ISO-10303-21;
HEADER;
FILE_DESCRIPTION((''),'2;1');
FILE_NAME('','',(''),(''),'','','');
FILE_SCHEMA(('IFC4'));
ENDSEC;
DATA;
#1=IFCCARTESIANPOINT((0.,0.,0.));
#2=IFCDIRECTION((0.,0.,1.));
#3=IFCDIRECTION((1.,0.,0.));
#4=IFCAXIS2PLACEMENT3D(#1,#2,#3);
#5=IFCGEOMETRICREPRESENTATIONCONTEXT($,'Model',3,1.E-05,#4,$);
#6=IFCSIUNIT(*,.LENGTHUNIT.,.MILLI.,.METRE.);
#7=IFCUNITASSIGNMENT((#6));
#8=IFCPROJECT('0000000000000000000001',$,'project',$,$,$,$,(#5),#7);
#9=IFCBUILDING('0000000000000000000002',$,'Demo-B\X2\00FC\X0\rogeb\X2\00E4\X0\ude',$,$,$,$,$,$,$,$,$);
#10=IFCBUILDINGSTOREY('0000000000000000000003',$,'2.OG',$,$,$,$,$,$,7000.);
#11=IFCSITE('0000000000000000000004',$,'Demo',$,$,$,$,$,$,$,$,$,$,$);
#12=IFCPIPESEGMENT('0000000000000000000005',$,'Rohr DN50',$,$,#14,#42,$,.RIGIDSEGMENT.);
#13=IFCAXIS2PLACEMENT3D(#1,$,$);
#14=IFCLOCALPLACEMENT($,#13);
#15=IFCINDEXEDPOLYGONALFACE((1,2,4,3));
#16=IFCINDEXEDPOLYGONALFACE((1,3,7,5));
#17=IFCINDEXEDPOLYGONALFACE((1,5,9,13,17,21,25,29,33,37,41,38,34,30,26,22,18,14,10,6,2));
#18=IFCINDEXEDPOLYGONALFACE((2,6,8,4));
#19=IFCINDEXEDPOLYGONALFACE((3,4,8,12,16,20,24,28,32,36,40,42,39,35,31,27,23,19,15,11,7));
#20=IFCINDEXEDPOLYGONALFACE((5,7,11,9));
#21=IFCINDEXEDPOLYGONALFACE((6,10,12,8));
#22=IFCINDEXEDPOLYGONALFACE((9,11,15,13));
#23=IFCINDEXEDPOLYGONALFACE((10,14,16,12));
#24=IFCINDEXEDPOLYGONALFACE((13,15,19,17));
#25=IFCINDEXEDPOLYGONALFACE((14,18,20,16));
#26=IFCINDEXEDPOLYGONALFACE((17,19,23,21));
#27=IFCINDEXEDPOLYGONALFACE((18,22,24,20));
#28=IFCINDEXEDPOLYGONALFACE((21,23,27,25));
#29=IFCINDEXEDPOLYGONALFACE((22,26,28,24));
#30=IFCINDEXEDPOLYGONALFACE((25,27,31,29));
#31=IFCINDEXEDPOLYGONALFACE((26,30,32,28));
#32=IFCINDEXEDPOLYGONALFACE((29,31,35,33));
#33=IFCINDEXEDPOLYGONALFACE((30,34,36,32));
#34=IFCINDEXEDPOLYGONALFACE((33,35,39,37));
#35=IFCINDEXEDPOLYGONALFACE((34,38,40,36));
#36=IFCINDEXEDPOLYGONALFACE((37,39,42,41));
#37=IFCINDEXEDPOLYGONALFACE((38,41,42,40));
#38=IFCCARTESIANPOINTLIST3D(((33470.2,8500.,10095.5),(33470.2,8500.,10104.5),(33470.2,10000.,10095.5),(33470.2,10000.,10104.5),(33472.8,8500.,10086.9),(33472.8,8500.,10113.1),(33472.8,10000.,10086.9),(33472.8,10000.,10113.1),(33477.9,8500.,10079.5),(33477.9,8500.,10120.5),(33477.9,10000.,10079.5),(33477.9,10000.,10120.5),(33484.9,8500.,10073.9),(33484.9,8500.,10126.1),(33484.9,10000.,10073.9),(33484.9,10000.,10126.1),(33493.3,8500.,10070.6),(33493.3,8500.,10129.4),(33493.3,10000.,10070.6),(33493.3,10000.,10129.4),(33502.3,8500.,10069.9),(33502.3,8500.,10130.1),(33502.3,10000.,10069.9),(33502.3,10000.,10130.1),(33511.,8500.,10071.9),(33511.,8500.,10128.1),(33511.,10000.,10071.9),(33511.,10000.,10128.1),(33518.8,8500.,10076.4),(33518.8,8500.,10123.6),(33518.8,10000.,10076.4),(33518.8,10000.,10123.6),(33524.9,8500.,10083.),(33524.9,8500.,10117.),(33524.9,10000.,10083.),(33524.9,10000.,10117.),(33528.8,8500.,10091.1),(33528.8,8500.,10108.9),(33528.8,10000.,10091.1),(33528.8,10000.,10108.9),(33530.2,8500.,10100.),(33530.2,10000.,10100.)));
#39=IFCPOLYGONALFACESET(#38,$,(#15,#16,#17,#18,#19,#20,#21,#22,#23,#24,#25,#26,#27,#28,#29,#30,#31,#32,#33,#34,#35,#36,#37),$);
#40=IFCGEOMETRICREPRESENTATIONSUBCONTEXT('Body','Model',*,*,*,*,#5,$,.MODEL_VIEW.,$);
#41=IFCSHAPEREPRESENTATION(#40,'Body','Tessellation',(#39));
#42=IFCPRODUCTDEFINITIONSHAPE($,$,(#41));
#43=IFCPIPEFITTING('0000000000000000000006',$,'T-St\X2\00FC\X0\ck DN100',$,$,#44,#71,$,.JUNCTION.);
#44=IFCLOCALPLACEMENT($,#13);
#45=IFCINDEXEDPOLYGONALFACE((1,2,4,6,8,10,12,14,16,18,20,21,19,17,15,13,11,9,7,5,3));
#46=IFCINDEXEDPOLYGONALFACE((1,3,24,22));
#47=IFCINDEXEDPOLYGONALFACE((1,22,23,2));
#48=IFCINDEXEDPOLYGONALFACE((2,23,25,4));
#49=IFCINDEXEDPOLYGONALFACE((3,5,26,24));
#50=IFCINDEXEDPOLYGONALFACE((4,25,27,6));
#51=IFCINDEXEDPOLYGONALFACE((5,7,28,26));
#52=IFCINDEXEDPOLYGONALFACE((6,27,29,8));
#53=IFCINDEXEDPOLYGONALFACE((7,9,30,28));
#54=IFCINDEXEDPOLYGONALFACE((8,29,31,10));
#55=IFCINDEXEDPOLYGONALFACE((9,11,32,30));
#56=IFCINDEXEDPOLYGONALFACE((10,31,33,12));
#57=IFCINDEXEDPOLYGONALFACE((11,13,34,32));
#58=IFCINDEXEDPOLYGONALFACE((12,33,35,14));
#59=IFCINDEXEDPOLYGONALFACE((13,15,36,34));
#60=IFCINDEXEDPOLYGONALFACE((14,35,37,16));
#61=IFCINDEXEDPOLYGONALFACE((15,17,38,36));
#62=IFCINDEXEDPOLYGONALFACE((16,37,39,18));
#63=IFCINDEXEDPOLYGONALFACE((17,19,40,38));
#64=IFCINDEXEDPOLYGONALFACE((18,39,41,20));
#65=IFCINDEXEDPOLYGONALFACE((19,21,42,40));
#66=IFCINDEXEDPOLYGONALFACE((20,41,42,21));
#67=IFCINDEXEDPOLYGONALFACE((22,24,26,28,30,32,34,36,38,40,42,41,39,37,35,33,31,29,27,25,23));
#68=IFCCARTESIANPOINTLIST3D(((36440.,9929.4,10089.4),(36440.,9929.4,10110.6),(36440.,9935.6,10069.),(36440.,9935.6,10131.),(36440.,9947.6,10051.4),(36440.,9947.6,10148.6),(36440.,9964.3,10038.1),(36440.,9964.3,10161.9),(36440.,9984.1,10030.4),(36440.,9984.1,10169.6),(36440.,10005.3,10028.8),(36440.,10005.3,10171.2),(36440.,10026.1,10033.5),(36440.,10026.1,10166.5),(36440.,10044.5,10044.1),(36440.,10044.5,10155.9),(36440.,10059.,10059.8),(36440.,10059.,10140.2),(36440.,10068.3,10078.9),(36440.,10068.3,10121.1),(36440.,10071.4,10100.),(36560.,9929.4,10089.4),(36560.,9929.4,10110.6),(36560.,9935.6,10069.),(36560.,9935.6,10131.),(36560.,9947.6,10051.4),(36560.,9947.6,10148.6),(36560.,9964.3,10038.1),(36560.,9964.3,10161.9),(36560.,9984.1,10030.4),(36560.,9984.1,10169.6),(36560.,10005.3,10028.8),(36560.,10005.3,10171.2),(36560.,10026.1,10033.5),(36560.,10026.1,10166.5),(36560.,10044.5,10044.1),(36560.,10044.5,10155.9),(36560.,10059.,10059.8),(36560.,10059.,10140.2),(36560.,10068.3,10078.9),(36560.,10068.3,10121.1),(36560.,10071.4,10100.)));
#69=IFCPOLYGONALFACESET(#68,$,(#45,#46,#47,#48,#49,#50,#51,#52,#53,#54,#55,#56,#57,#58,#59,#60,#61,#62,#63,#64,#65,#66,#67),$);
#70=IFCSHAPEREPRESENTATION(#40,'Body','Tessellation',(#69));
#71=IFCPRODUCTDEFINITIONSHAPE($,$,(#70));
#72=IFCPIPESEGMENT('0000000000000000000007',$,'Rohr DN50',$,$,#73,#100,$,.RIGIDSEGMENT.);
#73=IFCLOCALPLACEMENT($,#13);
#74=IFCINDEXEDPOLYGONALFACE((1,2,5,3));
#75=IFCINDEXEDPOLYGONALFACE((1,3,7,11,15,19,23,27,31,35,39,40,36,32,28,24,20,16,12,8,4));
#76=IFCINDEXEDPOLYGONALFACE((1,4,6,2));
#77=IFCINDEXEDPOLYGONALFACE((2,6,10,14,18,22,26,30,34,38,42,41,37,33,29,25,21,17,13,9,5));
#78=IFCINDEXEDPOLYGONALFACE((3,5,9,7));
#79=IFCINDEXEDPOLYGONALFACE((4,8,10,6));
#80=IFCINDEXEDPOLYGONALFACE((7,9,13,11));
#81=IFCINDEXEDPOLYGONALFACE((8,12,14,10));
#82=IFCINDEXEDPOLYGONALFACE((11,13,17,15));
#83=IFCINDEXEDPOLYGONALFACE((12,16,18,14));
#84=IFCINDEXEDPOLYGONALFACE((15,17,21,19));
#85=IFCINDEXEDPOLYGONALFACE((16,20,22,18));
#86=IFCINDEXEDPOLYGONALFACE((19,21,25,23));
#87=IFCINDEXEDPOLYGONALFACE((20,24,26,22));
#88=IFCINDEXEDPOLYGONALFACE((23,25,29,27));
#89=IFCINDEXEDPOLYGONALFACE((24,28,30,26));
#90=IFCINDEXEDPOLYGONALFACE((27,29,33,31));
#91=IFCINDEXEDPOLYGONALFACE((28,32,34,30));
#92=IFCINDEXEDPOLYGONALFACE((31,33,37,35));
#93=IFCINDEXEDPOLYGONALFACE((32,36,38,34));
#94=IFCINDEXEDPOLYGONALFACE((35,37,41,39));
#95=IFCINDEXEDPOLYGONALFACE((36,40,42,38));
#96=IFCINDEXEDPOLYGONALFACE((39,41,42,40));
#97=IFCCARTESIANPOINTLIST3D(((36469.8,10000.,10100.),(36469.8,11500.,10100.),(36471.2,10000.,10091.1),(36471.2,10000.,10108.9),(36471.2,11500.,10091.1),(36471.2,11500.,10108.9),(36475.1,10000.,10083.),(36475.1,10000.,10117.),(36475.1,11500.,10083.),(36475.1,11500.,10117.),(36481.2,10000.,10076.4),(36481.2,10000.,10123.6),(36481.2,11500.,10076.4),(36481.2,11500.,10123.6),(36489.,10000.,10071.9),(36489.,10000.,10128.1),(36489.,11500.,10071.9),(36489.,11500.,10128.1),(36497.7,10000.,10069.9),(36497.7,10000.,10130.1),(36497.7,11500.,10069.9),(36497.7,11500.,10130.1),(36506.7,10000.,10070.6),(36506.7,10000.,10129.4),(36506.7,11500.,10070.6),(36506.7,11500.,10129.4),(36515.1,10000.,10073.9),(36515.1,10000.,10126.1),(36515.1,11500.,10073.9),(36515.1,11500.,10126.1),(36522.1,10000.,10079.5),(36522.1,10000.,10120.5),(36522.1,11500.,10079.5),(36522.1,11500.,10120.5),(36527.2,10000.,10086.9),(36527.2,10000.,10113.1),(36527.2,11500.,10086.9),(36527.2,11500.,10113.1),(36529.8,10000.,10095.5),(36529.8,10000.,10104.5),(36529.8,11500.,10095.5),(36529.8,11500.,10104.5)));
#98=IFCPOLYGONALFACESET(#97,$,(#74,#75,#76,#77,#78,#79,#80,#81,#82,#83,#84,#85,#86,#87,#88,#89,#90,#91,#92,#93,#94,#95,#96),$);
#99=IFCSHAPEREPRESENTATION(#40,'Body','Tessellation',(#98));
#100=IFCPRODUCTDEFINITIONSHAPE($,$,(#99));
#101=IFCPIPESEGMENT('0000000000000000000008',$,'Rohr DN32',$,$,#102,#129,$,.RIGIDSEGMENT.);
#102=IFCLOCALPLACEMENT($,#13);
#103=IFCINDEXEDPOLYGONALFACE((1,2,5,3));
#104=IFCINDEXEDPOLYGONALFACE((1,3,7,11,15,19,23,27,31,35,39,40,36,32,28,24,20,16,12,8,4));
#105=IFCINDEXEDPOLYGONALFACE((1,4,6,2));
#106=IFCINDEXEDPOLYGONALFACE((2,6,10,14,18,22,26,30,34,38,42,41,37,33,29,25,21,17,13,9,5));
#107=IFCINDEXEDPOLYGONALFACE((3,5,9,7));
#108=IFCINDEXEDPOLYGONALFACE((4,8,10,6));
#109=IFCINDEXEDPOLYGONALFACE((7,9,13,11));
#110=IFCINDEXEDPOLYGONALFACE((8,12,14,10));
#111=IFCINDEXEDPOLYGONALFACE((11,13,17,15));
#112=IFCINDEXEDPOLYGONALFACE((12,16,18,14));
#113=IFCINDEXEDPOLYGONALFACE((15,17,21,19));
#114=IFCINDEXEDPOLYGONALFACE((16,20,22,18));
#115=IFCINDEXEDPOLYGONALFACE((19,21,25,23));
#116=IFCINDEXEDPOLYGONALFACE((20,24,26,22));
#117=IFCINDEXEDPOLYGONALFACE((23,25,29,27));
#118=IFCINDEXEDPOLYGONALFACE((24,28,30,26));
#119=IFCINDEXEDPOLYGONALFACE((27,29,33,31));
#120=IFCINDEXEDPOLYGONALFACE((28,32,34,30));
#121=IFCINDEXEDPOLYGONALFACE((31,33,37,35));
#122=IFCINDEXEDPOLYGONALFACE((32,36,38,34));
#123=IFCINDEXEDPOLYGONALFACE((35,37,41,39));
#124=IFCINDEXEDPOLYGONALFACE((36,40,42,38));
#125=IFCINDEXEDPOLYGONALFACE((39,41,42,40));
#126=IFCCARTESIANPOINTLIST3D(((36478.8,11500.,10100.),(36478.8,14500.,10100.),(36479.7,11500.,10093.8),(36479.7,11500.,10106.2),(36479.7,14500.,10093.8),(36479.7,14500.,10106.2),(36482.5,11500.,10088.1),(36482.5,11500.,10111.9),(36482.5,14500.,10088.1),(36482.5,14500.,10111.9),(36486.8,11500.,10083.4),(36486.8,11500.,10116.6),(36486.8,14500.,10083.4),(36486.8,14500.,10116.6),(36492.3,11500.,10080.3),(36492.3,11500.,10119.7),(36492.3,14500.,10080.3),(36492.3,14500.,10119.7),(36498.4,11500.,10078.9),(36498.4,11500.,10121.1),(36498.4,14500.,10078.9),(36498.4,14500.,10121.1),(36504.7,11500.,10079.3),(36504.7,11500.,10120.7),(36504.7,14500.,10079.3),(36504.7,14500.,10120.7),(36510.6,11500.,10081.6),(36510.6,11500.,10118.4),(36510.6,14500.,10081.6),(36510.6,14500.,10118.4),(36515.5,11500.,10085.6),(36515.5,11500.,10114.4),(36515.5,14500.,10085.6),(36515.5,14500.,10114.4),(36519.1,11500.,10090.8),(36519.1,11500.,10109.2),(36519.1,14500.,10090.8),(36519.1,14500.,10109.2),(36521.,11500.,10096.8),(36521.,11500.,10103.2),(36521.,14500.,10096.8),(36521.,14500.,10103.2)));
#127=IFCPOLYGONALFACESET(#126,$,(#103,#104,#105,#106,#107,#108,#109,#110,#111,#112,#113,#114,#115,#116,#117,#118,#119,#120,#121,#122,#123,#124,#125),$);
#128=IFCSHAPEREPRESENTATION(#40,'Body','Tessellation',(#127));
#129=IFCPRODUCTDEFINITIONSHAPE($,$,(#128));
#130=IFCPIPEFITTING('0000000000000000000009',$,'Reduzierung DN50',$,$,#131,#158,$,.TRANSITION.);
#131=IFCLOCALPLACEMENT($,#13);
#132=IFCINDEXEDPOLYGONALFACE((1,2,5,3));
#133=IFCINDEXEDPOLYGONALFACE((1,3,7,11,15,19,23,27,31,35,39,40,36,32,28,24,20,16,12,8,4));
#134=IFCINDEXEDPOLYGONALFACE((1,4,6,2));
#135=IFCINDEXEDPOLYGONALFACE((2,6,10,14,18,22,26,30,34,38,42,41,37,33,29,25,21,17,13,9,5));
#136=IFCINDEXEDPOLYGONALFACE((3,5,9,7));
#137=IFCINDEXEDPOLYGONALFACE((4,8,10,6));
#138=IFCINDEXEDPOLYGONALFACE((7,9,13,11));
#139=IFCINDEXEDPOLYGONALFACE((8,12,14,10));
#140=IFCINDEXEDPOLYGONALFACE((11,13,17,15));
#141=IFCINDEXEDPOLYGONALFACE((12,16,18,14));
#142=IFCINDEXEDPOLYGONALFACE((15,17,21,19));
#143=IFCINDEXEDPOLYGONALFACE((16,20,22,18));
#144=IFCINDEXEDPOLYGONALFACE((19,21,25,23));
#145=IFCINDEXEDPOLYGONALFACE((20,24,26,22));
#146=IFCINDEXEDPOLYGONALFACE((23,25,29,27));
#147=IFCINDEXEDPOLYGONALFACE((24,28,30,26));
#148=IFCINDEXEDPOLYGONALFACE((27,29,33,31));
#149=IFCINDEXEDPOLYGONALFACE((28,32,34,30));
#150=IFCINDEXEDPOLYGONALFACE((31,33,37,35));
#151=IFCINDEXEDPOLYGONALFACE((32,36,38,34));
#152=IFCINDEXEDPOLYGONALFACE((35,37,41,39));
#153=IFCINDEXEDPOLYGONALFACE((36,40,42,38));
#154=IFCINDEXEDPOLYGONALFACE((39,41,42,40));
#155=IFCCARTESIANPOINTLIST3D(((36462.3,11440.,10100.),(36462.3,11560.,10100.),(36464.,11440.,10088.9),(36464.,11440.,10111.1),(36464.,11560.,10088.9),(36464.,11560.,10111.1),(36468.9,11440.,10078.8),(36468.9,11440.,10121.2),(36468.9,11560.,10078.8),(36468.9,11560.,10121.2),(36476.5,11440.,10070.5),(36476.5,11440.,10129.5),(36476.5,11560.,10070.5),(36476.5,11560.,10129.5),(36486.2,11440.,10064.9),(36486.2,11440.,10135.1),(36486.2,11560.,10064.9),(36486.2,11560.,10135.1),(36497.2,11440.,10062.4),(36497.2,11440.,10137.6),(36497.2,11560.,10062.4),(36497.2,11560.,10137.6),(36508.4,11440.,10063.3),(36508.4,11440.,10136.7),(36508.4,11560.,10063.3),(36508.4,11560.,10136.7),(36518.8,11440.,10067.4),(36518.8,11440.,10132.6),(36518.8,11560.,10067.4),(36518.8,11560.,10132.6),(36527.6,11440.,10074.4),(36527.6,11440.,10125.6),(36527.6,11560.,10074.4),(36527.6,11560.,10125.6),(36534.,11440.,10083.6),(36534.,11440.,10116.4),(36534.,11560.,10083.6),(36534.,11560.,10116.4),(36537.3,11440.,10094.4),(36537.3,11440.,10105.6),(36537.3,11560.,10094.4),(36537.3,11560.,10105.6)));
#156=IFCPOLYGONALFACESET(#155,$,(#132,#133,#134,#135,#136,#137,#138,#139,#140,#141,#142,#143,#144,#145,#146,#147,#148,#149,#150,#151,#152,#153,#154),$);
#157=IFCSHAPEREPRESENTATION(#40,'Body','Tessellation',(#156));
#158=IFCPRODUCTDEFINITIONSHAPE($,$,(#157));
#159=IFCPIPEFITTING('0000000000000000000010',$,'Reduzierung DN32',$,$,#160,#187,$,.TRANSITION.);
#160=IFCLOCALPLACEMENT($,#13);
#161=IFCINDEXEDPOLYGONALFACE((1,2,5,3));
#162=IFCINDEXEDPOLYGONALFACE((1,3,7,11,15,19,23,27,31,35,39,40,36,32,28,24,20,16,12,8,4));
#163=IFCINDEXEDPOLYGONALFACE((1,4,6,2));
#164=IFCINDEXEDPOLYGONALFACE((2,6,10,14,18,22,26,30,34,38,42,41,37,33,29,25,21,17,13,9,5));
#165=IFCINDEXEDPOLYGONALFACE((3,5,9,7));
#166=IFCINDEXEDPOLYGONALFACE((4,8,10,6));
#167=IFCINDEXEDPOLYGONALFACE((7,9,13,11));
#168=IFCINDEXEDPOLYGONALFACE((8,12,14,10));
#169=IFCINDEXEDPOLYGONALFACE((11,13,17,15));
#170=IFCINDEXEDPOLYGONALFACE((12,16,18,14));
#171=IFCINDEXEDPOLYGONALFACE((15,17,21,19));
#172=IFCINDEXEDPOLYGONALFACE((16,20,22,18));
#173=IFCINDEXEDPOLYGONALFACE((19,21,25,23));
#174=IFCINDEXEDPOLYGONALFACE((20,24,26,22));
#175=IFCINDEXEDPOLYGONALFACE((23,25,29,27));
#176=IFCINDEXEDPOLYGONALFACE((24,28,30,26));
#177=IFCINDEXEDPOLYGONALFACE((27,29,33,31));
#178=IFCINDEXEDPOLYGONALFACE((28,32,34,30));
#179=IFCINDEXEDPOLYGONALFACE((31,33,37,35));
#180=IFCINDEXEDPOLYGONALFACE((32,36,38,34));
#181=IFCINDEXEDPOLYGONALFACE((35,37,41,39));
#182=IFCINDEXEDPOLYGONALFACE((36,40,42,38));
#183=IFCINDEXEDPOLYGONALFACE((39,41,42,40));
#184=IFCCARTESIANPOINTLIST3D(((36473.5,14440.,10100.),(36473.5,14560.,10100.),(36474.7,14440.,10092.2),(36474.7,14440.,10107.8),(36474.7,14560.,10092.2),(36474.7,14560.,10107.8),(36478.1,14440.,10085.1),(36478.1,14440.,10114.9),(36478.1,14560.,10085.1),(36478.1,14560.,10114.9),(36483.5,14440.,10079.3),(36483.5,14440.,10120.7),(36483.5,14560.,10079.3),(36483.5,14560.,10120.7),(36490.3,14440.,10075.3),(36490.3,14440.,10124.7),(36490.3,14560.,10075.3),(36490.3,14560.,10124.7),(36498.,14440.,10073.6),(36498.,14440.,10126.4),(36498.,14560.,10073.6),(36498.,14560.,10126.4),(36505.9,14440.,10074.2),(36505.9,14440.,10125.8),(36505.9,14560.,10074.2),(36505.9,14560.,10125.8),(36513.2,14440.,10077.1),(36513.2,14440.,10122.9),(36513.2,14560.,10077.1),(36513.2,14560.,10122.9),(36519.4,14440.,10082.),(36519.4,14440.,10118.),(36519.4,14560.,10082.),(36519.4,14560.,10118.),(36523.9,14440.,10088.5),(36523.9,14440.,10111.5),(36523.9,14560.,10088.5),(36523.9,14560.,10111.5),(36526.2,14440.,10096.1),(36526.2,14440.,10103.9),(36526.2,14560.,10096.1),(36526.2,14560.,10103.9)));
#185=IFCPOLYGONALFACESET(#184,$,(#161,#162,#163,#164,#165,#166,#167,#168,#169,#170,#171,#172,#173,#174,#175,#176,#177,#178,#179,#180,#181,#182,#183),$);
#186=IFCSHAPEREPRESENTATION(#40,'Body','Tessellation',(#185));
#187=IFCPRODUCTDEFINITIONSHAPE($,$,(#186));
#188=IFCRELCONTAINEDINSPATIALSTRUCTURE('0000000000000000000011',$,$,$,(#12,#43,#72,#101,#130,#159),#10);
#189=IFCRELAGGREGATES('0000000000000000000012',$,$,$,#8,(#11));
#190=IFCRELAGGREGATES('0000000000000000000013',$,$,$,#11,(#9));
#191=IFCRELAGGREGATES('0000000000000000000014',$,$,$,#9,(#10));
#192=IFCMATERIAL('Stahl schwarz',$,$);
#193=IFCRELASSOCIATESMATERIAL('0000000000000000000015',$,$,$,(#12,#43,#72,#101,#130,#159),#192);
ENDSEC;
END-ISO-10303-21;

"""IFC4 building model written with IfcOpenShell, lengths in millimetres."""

from ifc_helpers import new_model, si_unit, frame, origin_with_axes, place, context, subcontext, project, spatial, circle, extrude, material, element, save


model = new_model("IFC4")

# Units and contexts
model_context = context("Model", 3, precision=1e-05, world=origin_with_axes())
body_context = subcontext(model_context, "Body", "Model", "MODEL_VIEW")
ifc_project = project(units=[si_unit("LENGTHUNIT", "METRE", prefix="MILLI")], contexts=[model_context])

# Site, building, storey
site = spatial("IfcSite", under=ifc_project, Name="Demo")
building = spatial("IfcBuilding", under=site, Name="Demo-Bürogebäude")
storey = spatial("IfcBuildingStorey", under=building, Name="2.OG", Elevation=7000.0)

# Shared definitions
ifc_material_1 = material(Name="Stahl schwarz")

# Pipe segment
pipe_segment_1_placement = place(None, frame((33500.0, 10000.0, 10100.0), z_axis=(0.0, -1.0, 0.0), x_axis=(1.0, 0.0, 0.0)))
element("IfcPipeSegment", 1, at=pipe_segment_1_placement, inside=storey, material=ifc_material_1, Name="Rohr DN50", PredefinedType="RIGIDSEGMENT", context=body_context, shape_type="SweptSolid", body=[
    extrude(circle(Radius=30.1), origin_with_axes(), (0.0, 0.0, 1.0), 1500.0),
])

# Pipe fitting
pipe_fitting_1_placement = place(None, frame((36440.0, 10000.0, 10100.0), z_axis=(1.0, 0.0, 0.0), x_axis=(0.0, 1.0, 0.0)))
element("IfcPipeFitting", 2, at=pipe_fitting_1_placement, inside=storey, material=ifc_material_1, Name="T-Stück DN100", PredefinedType="JUNCTION", context=body_context, shape_type="SweptSolid", body=[
    extrude(circle(Radius=71.4), origin_with_axes(), (0.0, 0.0, 1.0), 120.0),
])

# Pipe segments
pipe_segment_2_placement = place(None, frame((36500.0, 10000.0, 10100.0), z_axis=(0.0, 1.0, 0.0), x_axis=(-1.0, 0.0, 0.0)))
element("IfcPipeSegment", 3, at=pipe_segment_2_placement, inside=storey, material=ifc_material_1, Name="Rohr DN50", PredefinedType="RIGIDSEGMENT", context=body_context, shape_type="SweptSolid", body=[
    extrude(circle(Radius=30.1), origin_with_axes(), (0.0, 0.0, 1.0), 1500.0),
])
pipe_segment_3_placement = place(None, frame((36500.0, 11500.0, 10100.0), z_axis=(0.0, 1.0, 0.0), x_axis=(-1.0, 0.0, 0.0)))
element("IfcPipeSegment", 4, at=pipe_segment_3_placement, inside=storey, material=ifc_material_1, Name="Rohr DN32", PredefinedType="RIGIDSEGMENT", context=body_context, shape_type="SweptSolid", body=[
    extrude(circle(Radius=21.2), origin_with_axes(), (0.0, 0.0, 1.0), 3000.0),
])

# Pipe fittings
pipe_fitting_2_placement = place(None, frame((36500.0, 11440.0, 10100.0), z_axis=(0.0, 1.0, 0.0), x_axis=(-1.0, 0.0, 0.0)))
element("IfcPipeFitting", 5, at=pipe_fitting_2_placement, inside=storey, material=ifc_material_1, Name="Reduzierung DN50", PredefinedType="TRANSITION", context=body_context, shape_type="SweptSolid", body=[
    extrude(circle(Radius=37.7), origin_with_axes(), (0.0, 0.0, 1.0), 120.0),
])
pipe_fitting_3_placement = place(None, frame((36500.0, 14440.0, 10100.0), z_axis=(0.0, 1.0, 0.0), x_axis=(-1.0, 0.0, 0.0)))
element("IfcPipeFitting", 6, at=pipe_fitting_3_placement, inside=storey, material=ifc_material_1, Name="Reduzierung DN32", PredefinedType="TRANSITION", context=body_context, shape_type="SweptSolid", body=[
    extrude(circle(Radius=26.5), origin_with_axes(), (0.0, 0.0, 1.0), 120.0),
])

save(model, "model.ifc")
